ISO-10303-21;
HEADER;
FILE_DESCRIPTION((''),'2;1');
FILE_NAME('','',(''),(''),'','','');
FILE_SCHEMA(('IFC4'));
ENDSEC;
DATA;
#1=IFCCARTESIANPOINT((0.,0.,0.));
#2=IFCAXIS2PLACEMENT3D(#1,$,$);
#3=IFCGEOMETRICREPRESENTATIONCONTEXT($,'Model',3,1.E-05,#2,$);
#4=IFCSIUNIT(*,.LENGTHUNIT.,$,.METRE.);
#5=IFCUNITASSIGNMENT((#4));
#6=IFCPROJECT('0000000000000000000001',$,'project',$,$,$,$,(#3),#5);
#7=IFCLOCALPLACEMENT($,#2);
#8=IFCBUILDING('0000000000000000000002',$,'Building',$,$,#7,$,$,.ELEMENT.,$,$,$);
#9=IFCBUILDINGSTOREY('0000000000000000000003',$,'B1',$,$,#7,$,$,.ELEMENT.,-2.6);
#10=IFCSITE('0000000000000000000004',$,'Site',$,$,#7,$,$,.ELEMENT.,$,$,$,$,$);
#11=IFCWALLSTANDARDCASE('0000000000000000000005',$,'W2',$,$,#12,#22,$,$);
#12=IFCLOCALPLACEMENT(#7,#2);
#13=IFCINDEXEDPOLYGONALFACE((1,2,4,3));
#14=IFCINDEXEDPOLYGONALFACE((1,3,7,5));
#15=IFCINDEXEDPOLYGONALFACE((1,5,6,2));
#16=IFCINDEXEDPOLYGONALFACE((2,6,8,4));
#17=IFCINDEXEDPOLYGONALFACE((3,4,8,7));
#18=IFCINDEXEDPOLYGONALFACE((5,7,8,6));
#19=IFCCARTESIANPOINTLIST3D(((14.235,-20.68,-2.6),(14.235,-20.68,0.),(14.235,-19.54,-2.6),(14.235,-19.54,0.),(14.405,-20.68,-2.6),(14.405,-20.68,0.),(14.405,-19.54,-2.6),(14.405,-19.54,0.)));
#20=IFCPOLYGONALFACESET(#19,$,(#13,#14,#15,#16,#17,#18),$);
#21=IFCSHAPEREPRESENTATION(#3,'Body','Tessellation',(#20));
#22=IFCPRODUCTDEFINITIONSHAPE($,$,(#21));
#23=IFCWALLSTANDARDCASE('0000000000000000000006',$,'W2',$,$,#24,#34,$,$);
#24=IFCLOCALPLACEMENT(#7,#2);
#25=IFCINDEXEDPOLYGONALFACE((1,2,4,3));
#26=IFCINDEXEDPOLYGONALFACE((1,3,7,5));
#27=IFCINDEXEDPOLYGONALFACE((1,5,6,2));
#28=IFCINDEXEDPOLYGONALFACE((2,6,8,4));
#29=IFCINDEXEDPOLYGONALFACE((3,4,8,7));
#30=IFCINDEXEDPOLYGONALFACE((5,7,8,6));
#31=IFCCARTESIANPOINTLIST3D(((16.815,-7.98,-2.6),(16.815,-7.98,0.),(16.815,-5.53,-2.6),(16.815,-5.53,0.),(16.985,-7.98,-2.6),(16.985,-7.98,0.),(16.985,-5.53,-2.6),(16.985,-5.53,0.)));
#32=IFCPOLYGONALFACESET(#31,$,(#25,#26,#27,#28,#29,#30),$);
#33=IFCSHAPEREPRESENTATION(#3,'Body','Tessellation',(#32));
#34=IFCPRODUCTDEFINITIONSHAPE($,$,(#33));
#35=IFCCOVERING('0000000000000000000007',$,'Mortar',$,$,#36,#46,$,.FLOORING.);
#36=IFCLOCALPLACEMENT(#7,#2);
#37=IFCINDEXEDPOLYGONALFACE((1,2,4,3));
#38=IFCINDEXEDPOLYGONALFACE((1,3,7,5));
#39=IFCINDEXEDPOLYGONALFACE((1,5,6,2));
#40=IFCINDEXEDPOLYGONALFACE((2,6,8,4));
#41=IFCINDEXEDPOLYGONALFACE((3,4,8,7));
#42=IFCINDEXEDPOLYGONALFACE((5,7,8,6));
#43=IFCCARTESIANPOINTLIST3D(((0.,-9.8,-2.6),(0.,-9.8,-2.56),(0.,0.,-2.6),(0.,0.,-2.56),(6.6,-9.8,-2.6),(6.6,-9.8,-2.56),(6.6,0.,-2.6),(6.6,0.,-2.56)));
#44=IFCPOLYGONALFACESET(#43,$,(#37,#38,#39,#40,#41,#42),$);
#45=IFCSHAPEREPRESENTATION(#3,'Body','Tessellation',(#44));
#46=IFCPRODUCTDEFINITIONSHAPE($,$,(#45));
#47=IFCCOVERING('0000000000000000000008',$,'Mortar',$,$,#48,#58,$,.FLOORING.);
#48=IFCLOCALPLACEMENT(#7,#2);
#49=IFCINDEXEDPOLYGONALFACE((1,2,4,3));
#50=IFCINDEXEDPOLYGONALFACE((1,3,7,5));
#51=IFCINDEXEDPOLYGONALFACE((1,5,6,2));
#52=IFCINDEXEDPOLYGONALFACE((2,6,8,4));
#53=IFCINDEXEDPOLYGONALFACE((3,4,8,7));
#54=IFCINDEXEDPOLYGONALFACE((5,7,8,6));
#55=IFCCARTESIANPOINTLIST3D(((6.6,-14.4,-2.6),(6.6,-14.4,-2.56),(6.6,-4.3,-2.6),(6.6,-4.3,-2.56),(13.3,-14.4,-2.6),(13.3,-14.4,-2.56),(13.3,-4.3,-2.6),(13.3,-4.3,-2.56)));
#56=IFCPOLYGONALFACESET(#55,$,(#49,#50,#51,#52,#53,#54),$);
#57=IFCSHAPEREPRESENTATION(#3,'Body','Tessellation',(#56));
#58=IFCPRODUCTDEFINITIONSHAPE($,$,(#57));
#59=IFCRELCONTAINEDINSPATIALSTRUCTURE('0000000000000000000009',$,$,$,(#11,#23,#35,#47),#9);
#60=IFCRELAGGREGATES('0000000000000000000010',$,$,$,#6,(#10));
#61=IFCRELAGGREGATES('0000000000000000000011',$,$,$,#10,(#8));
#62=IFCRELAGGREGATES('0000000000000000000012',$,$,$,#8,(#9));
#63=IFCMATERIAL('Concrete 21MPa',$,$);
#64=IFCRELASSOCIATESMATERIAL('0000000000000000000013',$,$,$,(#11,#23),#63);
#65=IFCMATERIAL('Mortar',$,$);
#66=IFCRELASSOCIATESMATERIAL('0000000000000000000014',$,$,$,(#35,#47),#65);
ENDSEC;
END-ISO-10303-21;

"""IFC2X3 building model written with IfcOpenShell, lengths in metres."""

from ifc_helpers import new_model, si_unit, frame, origin, origin_2d, place, context, project, spatial, rectangle, extrude, material, element, save


model = new_model("IFC2X3")

# Units and contexts
model_context = context("Model", 3, precision=1e-05, world=origin())
ifc_project = project(units=[si_unit("LENGTHUNIT", "METRE")], contexts=[model_context])

# Site, building, storey
placement = place(None, origin())
site = spatial("IfcSite", under=ifc_project, at=placement, Name="Site", CompositionType="ELEMENT")
building = spatial("IfcBuilding", under=site, at=placement, Name="Building", CompositionType="ELEMENT")
storey = spatial("IfcBuildingStorey", under=building, at=placement, Name="B1", CompositionType="ELEMENT", Elevation=-2.6)

# Shared definitions
ifc_material_1 = material(Name="Concrete 21MPa")

# Walls
wall_1_placement = place(None, frame((14.32, -20.11, -2.6)))
element("IfcWallStandardCase", 1, at=wall_1_placement, inside=storey, material=ifc_material_1, Name="W2", context=model_context, shape_type="SweptSolid", body=[
    extrude(rectangle(XDim=0.17, YDim=1.14, at=origin_2d()), origin(), (0.0, 0.0, 1.0), 2.6),
])
wall_2_placement = place(None, frame((16.9, -6.755, -2.6)))
element("IfcWallStandardCase", 2, at=wall_2_placement, inside=storey, material=ifc_material_1, Name="W2", context=model_context, shape_type="SweptSolid", body=[
    extrude(rectangle(XDim=0.17, YDim=2.45, at=origin_2d()), origin(), (0.0, 0.0, 1.0), 2.6),
])

# Coverings
ifc_material_2 = material(Name="Mortar")
covering_1_placement = place(None, frame((3.3, -4.9, -2.6)))
element("IfcCovering", 3, at=covering_1_placement, inside=storey, material=ifc_material_2, Name="Mortar", PredefinedType="FLOORING", context=model_context, shape_type="SweptSolid", body=[
    extrude(rectangle(XDim=6.6, YDim=9.8, at=origin_2d()), origin(), (0.0, 0.0, 1.0), 0.04),
])
covering_2_placement = place(None, frame((9.95, -9.35, -2.6)))
element("IfcCovering", 4, at=covering_2_placement, inside=storey, material=ifc_material_2, Name="Mortar", PredefinedType="FLOORING", context=model_context, shape_type="SweptSolid", body=[
    extrude(rectangle(XDim=6.7, YDim=10.1, at=origin_2d()), origin(), (0.0, 0.0, 1.0), 0.04),
])

save(model, "model.ifc")
